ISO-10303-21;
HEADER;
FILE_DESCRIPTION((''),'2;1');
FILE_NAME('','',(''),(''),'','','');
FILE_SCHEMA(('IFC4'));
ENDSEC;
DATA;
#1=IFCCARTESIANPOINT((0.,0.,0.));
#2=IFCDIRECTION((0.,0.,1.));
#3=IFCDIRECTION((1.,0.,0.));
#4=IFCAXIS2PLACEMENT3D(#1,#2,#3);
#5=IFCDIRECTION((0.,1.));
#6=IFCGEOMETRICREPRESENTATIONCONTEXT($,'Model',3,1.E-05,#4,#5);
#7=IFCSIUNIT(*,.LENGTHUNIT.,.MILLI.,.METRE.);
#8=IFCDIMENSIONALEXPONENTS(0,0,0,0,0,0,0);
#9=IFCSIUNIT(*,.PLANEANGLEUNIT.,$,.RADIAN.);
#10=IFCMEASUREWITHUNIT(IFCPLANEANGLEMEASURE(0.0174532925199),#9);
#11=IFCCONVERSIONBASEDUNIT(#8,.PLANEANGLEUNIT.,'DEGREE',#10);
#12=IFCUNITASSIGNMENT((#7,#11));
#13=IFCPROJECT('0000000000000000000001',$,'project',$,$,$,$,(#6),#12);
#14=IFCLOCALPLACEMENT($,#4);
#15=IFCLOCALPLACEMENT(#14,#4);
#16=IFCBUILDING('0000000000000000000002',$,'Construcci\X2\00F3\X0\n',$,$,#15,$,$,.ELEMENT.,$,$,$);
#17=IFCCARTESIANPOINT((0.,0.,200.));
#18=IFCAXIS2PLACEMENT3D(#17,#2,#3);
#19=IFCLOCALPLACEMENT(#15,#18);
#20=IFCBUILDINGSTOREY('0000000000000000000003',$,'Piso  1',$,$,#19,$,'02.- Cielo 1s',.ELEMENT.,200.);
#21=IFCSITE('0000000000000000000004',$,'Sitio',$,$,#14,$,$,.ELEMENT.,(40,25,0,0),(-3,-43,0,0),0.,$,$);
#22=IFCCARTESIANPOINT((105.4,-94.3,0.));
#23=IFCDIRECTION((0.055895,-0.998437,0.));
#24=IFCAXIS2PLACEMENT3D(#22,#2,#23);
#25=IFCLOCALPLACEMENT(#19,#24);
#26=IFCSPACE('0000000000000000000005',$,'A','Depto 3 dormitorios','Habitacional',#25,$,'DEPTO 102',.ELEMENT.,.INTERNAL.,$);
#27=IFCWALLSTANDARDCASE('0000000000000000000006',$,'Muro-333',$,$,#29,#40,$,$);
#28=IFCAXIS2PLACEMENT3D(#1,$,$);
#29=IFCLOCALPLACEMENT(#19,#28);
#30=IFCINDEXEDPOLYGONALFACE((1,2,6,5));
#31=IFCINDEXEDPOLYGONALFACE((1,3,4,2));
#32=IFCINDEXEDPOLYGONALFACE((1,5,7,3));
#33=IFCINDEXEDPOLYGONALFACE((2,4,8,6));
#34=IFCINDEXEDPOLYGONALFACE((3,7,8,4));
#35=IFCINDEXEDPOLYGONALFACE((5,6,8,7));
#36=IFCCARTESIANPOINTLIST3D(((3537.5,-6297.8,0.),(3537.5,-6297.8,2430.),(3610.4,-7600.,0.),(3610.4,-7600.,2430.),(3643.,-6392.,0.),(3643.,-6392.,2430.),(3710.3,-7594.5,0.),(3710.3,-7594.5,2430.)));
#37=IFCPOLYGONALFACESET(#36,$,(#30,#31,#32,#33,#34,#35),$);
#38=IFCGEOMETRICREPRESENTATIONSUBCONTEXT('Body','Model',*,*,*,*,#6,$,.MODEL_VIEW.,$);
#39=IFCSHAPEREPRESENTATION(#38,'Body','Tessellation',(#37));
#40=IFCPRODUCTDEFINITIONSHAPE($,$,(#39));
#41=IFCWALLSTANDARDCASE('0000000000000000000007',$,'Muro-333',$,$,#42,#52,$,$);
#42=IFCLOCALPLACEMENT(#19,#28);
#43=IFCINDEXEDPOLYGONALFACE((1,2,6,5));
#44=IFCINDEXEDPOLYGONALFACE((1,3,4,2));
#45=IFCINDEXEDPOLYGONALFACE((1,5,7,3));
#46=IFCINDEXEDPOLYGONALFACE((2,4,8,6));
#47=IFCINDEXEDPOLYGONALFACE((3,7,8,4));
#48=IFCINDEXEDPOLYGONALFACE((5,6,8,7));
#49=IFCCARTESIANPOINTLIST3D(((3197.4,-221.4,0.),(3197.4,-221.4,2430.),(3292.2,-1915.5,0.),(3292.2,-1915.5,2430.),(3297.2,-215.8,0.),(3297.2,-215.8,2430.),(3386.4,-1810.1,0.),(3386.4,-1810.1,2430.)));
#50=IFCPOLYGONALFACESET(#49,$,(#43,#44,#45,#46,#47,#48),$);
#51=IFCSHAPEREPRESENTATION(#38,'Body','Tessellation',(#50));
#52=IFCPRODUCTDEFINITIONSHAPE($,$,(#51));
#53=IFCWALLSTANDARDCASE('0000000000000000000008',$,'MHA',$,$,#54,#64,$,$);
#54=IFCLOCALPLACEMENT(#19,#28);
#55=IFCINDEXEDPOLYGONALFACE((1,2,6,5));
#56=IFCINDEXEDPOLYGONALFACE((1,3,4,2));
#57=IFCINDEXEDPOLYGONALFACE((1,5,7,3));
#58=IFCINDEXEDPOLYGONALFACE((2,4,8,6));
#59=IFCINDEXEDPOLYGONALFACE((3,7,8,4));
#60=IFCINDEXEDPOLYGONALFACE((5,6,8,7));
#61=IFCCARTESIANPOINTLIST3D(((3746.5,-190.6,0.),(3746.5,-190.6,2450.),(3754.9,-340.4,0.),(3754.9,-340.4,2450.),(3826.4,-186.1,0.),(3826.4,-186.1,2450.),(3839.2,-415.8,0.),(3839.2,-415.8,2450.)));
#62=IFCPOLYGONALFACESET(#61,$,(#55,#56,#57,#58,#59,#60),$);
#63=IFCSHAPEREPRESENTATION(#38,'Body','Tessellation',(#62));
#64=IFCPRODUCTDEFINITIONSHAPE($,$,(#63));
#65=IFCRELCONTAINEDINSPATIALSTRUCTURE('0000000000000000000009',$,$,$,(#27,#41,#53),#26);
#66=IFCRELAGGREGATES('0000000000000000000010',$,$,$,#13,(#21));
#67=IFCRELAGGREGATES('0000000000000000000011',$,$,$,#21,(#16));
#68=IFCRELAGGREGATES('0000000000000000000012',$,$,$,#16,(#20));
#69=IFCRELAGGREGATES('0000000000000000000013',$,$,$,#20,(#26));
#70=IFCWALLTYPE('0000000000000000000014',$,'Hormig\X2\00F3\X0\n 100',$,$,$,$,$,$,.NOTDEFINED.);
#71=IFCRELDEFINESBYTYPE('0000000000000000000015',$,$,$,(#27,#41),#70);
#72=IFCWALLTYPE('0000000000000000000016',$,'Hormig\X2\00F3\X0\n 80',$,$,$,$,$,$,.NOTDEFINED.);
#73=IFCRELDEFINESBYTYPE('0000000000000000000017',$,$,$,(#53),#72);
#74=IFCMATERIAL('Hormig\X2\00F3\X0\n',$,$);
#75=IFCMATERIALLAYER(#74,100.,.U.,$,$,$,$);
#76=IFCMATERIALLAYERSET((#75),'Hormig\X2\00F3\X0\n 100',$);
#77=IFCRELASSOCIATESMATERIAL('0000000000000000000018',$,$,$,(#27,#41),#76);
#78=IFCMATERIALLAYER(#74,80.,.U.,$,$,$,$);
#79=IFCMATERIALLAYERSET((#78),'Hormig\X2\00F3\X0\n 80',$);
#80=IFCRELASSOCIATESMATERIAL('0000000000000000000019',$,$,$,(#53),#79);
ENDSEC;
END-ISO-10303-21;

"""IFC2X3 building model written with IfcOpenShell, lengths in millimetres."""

from ifc_helpers import new_model, entity, si_unit, converted_unit, direction, frame, origin_with_axes, place, context, subcontext, project, spatial, polyline, outline, extrude, material, layer, layer_set, layer_usage, type_object, element, save


model = new_model("IFC2X3")

# Units and contexts
model_context = context("Model", 3, precision=1e-05, world=origin_with_axes(), true_north=direction((0.0, 1.0)))
body_context = subcontext(model_context, "Body", "Model", "MODEL_VIEW")
ifc_project = project(units=[si_unit("LENGTHUNIT", "METRE", prefix="MILLI"), converted_unit("PLANEANGLEUNIT", "DEGREE", entity("IfcPlaneAngleMeasure", 0.0174532925199), si_unit("PLANEANGLEUNIT", "RADIAN"), dimensions=[0, 0, 0, 0, 0, 0, 0])], contexts=[model_context])

# Site, building, storey
site_placement = place(None, origin_with_axes())
site = spatial("IfcSite", under=ifc_project, at=site_placement, Name="Sitio", CompositionType="ELEMENT", RefLatitude=(40, 25, 0, 0), RefLongitude=(-3, -43, 0, 0), RefElevation=0.0)
building_placement = place(site_placement, origin_with_axes())
building = spatial("IfcBuilding", under=site, at=building_placement, Name="Construcción", CompositionType="ELEMENT")
storey_placement = place(building_placement, frame((0.0, 0.0, 200.0), z_axis=(0.0, 0.0, 1.0), x_axis=(1.0, 0.0, 0.0)))
storey = spatial("IfcBuildingStorey", under=building, at=storey_placement, Name="Piso  1", LongName="02.- Cielo 1s", CompositionType="ELEMENT", Elevation=200.0)

# Shared definitions
ifc_material = material(Name="Hormigón")

# Shared definitions
space_placement = place(storey_placement, frame((105.4, -94.3, 0.0), z_axis=(0.0, 0.0, 1.0), x_axis=(0.055895, -0.998437, 0.0)))
space = spatial("IfcSpace", under=storey, at=space_placement, Name="A", Description="Depto 3 dormitorios", ObjectType="Habitacional", LongName="DEPTO 102", CompositionType="ELEMENT", InteriorOrExteriorSpace="INTERNAL")

# Wall
ifc_layer_1 = layer(ifc_material, 100.0, ventilated="UNKNOWN")
ifc_layer_set_1 = layer_set([ifc_layer_1], Name="Hormigón 100")
wall_type_1 = type_object("IfcWallType", Name="Hormigón 100", PredefinedType="NOTDEFINED")
ifc_layer_usage_1 = layer_usage(ifc_layer_set_1, "AXIS2", "NEGATIVE", 0.0)
wall_1_placement = place(space_placement, frame((7790.0, 3080.0, 0.0), z_axis=(0.0, 0.0, 1.0), x_axis=(-1.0, 0.0, 0.0)))
element("IfcWallStandardCase", 1, at=wall_1_placement, inside=space, type_object=wall_type_1, material=ifc_layer_usage_1, Name="Muro-333", context=body_context, shape_type="SweptSolid", body=[
    extrude(outline(polyline([(100.0, -100.0), (1304.3, -100.0), (1404.3, 0.0), (100.0, 0.0), (100.0, -100.0)])), origin_with_axes(), (0.0, 0.0, 1.0), 2430.0),
])

# Wall
ifc_layer_usage_2 = layer_usage(ifc_layer_set_1, "AXIS2", "NEGATIVE", 100.0)
wall_2_placement = place(space_placement, frame((199.7, 3080.0, 0.0), z_axis=(0.0, 0.0, 1.0), x_axis=(1.0, 0.0, 0.0)))
element("IfcWallStandardCase", 2, at=wall_2_placement, inside=space, type_object=wall_type_1, material=ifc_layer_usage_2, Name="Muro-333", context=body_context, shape_type="SweptSolid", body=[
    extrude(outline(polyline([(100.0, 0.0), (1796.8, 0.0), (1696.8, 100.0), (100.0, 100.0), (100.0, 0.0)])), origin_with_axes(), (0.0, 0.0, 1.0), 2430.0),
])

# Wall
ifc_layer_2 = layer(ifc_material, 80.0, ventilated="UNKNOWN")
ifc_layer_set_2 = layer_set([ifc_layer_2], Name="Hormigón 80")
wall_type_2 = type_object("IfcWallType", Name="Hormigón 80", PredefinedType="NOTDEFINED")
ifc_layer_usage_3 = layer_usage(ifc_layer_set_2, "AXIS2", "POSITIVE", -80.0)
wall_3_placement = place(space_placement, frame((449.7, 3630.0, 0.0), z_axis=(0.0, 0.0, 1.0), x_axis=(-1.0, -0.000005, 0.0)))
element("IfcWallStandardCase", 3, at=wall_3_placement, inside=space, type_object=wall_type_2, material=ifc_layer_usage_3, Name="MHA", context=body_context, shape_type="SweptSolid", body=[
    extrude(outline(polyline([(-80.0, -80.0), (150.0, -80.0), (150.0, 0.0), (0.0, 0.0), (-80.0, -80.0)])), origin_with_axes(), (0.0, 0.0, 1.0), 2450.0),
])

save(model, "model.ifc")
